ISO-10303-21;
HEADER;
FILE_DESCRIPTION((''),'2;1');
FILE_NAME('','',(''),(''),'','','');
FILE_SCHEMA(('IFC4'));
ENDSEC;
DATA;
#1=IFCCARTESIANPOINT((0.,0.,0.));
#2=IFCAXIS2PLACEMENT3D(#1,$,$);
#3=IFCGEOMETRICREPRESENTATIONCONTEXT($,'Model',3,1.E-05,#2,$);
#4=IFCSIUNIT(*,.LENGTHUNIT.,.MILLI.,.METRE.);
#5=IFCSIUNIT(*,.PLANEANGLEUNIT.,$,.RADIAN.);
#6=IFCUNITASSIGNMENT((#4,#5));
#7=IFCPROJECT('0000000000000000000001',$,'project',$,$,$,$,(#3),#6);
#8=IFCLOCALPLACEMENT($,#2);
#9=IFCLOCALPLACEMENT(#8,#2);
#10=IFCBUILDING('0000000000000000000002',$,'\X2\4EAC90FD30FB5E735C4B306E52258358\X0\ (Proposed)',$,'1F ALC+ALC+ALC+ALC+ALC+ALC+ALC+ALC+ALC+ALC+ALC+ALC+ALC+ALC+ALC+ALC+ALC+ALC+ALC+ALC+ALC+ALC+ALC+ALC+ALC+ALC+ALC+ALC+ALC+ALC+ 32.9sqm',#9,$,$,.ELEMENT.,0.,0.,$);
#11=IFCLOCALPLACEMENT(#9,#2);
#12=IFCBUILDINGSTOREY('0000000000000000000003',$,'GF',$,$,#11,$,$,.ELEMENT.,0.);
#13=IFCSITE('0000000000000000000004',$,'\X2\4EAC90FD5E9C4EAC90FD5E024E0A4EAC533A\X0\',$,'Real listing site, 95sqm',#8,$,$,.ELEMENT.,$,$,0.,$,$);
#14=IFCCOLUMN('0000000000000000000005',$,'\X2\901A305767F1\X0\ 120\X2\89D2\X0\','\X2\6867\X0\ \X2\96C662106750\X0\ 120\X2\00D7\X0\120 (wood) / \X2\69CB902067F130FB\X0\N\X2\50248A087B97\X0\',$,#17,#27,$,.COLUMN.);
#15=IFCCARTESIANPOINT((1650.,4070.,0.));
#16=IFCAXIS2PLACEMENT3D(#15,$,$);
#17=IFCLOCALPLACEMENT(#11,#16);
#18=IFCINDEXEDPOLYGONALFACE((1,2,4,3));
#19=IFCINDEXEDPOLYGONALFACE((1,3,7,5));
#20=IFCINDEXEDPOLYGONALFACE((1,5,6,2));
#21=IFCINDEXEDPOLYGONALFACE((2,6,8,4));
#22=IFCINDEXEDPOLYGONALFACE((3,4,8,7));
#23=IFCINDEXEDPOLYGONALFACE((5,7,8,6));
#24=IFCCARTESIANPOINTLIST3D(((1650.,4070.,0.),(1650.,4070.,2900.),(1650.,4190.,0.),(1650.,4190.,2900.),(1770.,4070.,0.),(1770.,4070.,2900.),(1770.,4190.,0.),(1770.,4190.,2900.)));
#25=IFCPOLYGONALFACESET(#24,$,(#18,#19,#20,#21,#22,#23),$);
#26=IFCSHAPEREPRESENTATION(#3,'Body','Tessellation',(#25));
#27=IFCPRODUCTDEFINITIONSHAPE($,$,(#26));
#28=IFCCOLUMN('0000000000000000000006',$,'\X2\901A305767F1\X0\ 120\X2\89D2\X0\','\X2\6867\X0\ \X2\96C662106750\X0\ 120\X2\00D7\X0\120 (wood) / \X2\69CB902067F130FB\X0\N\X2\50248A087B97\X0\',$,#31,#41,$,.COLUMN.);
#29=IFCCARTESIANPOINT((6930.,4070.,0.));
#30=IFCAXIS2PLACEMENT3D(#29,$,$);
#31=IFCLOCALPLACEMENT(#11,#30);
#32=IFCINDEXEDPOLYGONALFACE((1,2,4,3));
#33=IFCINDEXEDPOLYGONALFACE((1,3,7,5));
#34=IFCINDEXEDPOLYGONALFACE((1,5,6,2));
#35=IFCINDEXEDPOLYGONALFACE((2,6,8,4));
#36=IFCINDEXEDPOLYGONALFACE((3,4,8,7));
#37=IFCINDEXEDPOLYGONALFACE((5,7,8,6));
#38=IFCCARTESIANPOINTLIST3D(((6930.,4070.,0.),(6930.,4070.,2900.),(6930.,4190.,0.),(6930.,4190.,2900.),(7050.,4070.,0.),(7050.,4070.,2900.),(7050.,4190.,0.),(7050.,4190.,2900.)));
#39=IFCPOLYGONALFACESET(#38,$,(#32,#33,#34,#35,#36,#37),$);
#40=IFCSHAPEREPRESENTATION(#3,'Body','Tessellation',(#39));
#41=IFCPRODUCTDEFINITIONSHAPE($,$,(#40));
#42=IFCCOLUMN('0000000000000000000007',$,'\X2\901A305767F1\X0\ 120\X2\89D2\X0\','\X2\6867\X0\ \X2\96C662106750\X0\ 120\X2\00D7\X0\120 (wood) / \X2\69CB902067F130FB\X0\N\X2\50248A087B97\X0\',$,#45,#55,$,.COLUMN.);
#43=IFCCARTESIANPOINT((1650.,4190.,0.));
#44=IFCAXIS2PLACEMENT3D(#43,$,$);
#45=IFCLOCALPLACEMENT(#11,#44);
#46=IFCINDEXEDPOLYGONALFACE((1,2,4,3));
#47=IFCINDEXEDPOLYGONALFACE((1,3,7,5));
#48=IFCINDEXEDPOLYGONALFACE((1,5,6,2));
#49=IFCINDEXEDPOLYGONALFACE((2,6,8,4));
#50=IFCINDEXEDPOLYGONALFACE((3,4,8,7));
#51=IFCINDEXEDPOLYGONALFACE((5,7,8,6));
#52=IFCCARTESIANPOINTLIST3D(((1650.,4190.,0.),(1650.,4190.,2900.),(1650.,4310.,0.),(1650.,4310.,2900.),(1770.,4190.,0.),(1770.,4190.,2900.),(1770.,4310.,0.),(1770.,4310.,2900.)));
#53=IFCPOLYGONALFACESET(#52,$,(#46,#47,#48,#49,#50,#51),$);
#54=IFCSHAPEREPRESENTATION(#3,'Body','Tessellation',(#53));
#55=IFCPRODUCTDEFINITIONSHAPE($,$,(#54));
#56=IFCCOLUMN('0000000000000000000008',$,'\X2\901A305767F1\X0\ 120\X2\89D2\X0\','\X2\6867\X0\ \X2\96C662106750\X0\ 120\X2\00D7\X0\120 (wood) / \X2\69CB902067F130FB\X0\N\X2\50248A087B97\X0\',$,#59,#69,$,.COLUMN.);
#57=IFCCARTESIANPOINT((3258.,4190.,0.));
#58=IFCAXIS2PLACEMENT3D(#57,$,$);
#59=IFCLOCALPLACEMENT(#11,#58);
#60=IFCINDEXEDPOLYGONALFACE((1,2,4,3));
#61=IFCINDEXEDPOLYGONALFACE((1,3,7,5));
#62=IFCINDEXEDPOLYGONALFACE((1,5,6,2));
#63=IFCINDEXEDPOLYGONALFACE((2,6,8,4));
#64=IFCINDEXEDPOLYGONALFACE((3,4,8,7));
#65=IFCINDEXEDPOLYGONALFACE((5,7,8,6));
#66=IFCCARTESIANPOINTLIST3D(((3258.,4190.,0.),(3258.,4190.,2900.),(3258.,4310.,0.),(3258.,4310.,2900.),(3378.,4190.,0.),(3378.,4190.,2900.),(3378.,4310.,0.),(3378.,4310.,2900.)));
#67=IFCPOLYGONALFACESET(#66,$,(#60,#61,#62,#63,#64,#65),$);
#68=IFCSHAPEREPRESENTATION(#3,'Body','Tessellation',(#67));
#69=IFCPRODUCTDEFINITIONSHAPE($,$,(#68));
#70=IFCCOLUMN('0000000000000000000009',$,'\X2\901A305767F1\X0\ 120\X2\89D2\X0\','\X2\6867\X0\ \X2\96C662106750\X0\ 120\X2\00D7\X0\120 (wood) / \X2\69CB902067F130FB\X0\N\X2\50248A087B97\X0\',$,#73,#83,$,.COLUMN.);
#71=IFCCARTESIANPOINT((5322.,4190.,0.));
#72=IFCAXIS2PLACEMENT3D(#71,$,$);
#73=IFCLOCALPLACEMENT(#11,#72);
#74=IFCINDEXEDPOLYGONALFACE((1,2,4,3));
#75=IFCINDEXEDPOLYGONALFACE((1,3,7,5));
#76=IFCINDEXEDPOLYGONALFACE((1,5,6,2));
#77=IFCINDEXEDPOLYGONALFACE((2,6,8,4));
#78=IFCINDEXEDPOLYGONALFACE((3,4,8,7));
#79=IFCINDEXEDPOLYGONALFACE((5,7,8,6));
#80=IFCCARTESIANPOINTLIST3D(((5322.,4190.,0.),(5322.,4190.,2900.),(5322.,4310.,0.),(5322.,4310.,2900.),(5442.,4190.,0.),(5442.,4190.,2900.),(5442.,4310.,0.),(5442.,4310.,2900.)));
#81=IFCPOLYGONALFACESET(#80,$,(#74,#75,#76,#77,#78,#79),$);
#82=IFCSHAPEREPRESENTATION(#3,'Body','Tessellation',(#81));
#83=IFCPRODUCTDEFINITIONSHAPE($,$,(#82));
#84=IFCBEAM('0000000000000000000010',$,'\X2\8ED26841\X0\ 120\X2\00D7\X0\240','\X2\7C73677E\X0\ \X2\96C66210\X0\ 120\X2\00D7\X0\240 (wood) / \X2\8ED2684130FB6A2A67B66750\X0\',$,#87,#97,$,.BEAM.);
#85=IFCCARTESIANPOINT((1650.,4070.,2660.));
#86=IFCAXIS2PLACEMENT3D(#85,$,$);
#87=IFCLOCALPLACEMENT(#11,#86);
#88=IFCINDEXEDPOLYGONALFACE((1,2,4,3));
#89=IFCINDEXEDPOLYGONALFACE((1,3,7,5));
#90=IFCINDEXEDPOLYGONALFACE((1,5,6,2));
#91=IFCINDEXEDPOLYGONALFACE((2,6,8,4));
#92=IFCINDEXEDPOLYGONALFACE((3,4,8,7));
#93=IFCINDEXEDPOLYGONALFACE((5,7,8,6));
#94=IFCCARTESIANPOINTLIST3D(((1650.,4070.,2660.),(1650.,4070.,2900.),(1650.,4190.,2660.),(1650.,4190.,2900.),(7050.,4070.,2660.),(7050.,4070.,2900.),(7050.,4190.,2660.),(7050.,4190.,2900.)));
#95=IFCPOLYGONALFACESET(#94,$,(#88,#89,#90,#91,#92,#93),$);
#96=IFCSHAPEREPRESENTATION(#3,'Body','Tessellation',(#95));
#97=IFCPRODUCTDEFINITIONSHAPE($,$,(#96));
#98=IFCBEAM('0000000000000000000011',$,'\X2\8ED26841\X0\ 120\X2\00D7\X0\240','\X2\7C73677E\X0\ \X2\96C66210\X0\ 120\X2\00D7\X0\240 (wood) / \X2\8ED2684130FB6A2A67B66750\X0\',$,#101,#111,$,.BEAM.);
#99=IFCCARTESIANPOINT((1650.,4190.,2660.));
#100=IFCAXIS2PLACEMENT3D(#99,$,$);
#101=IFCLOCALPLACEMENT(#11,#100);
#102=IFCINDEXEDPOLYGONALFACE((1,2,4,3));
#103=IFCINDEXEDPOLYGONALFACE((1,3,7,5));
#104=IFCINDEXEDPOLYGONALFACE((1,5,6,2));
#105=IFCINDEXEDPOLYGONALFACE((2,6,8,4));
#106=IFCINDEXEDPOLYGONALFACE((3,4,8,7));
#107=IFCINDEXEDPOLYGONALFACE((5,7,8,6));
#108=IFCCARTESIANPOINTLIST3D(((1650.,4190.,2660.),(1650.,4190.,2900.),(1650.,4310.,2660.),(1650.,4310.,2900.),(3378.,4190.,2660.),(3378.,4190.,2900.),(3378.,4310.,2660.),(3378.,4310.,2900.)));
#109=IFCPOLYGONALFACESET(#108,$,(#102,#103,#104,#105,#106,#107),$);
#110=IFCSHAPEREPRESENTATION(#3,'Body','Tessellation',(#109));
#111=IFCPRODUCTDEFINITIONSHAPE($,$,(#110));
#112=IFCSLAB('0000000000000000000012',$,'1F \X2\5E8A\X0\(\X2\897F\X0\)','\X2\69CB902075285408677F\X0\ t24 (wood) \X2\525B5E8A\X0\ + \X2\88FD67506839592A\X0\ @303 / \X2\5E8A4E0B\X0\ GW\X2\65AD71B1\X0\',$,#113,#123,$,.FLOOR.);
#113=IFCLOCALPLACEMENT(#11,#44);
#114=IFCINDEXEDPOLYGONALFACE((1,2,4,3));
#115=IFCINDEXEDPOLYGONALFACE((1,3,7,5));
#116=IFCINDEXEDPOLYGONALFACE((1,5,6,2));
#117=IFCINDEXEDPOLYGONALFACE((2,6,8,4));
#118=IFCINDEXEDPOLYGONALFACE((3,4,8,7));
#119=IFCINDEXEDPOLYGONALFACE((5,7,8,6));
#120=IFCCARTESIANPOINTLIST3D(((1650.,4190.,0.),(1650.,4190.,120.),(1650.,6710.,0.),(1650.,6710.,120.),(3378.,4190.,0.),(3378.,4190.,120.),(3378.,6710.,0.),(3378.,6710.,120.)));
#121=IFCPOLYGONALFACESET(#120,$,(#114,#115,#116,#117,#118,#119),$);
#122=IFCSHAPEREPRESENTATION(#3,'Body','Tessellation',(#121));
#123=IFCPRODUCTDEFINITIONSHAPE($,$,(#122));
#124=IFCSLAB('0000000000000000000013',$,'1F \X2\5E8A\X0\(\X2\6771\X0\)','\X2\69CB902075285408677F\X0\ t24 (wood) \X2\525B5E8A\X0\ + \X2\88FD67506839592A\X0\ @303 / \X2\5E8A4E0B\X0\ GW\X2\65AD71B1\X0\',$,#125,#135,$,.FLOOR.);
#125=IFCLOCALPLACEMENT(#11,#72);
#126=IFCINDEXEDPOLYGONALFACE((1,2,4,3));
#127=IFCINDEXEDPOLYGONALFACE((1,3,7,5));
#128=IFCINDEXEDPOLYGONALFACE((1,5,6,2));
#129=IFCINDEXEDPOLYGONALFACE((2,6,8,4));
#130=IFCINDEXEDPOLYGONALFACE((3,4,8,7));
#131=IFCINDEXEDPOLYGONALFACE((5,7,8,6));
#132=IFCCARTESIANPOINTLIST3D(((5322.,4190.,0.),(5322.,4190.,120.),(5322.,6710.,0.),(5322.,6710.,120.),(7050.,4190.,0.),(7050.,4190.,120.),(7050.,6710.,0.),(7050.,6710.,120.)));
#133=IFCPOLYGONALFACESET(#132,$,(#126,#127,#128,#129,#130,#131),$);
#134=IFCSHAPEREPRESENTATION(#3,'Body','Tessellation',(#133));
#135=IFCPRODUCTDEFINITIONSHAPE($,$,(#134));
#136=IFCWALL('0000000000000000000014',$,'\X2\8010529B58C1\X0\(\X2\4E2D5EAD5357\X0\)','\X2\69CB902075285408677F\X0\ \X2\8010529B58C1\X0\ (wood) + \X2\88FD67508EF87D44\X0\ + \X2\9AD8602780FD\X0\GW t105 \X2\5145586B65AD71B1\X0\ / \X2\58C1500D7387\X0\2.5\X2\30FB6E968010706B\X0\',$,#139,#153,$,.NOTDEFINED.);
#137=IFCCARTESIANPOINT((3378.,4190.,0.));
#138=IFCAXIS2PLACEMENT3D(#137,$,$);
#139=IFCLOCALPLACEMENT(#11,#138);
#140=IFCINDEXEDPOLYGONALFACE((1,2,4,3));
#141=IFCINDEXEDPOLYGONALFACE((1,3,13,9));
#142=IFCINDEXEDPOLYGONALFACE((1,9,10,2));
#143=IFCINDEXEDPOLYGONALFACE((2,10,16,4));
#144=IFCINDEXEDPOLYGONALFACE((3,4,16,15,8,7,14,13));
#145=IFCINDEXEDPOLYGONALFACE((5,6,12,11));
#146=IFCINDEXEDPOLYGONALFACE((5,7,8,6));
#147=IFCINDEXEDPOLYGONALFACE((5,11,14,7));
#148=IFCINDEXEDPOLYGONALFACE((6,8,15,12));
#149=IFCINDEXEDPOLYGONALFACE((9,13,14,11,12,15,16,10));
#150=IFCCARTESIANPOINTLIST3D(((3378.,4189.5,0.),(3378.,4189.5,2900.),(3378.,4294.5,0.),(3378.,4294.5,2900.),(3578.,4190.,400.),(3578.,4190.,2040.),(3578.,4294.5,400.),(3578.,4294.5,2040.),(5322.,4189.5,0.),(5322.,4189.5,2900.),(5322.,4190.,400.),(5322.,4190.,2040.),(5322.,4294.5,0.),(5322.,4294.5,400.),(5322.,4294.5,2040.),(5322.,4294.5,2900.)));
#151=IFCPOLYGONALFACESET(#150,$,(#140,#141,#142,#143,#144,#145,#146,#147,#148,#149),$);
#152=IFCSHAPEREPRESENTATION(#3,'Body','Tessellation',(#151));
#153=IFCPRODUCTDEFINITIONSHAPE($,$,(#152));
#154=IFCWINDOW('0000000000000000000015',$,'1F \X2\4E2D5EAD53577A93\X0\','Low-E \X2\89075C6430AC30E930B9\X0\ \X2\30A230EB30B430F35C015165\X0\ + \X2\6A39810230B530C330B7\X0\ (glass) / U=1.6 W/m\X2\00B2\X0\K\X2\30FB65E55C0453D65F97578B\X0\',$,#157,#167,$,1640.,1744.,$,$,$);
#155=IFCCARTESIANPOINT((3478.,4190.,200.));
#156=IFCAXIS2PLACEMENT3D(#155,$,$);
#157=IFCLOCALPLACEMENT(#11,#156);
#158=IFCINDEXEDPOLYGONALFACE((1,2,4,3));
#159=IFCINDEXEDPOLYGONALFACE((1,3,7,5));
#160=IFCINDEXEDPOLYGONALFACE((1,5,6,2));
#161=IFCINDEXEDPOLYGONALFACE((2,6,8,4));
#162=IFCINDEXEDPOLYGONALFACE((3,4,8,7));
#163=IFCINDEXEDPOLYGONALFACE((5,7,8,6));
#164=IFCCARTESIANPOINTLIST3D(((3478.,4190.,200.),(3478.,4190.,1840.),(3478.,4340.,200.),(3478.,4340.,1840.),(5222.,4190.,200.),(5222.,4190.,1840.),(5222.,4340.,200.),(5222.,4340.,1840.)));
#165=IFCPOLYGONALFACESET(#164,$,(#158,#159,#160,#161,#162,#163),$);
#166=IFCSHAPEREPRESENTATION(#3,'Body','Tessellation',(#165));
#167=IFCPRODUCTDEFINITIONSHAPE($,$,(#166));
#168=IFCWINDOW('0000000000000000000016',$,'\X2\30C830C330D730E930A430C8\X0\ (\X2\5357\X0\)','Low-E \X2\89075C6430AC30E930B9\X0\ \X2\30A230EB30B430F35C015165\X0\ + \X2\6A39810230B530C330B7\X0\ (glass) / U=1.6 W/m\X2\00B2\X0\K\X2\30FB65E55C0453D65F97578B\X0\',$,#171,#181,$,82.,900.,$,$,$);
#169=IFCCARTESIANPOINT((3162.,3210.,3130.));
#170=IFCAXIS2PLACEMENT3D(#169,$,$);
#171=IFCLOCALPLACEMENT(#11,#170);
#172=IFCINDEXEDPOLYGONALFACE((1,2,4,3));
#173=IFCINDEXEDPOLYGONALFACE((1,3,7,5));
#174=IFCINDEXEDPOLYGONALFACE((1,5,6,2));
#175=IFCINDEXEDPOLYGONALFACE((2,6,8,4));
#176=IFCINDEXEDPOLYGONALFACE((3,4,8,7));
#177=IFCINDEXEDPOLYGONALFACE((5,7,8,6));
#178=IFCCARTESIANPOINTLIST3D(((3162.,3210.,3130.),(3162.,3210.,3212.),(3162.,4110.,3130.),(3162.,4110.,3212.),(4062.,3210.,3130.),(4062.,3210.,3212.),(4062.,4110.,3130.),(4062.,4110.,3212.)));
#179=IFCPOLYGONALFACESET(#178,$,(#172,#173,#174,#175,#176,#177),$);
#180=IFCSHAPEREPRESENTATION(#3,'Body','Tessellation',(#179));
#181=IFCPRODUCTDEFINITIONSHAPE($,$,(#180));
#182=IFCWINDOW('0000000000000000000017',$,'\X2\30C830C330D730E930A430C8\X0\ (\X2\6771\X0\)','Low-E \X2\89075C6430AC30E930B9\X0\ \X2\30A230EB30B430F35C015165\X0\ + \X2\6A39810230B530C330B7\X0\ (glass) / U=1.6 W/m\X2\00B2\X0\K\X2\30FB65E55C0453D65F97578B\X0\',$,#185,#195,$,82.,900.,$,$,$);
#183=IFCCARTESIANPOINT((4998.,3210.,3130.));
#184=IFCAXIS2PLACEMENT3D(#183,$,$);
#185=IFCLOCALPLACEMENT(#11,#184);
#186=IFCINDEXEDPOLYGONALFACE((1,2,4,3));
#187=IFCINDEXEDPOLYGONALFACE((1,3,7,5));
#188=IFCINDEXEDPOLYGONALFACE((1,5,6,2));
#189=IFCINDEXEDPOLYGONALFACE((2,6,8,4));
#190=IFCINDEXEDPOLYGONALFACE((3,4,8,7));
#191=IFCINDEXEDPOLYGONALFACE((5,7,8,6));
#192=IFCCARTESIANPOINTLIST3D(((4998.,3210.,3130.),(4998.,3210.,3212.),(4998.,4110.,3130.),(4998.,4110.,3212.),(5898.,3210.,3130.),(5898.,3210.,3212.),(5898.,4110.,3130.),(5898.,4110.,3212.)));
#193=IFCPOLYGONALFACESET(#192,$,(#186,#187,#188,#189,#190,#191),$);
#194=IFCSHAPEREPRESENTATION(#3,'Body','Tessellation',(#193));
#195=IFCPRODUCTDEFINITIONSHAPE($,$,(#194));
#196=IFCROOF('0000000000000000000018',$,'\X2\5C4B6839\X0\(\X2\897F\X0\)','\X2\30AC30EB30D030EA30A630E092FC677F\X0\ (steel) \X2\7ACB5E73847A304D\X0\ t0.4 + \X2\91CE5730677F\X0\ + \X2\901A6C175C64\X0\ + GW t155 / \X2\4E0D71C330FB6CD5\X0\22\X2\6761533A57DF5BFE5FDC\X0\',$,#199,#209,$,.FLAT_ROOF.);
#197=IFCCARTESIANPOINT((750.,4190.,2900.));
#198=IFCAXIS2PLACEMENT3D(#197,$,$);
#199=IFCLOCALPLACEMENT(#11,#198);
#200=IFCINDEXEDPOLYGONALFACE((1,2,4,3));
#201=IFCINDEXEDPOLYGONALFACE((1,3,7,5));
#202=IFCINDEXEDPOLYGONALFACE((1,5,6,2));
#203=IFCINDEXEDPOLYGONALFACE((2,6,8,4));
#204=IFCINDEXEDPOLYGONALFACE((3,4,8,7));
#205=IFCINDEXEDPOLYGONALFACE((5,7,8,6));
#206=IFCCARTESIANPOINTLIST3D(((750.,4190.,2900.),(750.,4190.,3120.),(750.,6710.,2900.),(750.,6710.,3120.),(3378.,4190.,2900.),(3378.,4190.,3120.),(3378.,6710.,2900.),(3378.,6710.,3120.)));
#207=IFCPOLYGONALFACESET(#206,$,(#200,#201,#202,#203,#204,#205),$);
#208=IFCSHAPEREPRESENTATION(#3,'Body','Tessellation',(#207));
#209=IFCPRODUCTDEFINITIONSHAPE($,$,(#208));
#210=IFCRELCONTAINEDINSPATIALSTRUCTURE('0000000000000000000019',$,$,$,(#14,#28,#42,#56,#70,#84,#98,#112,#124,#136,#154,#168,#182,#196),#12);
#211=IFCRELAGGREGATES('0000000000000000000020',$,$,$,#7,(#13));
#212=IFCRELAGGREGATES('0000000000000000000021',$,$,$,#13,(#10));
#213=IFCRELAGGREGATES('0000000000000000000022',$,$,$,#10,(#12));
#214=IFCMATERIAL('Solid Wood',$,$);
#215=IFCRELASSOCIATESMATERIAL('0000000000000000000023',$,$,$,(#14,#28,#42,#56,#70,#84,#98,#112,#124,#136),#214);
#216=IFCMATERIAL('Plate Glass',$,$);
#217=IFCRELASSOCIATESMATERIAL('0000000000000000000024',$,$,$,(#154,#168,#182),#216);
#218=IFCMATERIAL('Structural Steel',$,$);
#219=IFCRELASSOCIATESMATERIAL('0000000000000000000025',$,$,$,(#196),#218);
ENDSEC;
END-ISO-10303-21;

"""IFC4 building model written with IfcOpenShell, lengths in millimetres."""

from ifc_helpers import new_model, si_unit, frame, frame_2d, origin, place, context, project, spatial, rectangle, extrude, material, element, fill, save


model = new_model("IFC4")

# Units and contexts
model_context = context("Model", 3, precision=1e-05, world=origin())
ifc_project = project(units=[si_unit("LENGTHUNIT", "METRE", prefix="MILLI"), si_unit("PLANEANGLEUNIT", "RADIAN")], contexts=[model_context])

# Site, building, storey
site_placement = place(None, origin())
site = spatial("IfcSite", under=ifc_project, at=site_placement, Name="京都府京都市上京区", ObjectType="Real listing site, 95sqm", CompositionType="ELEMENT", RefElevation=0.0)
building_placement = place(site_placement, origin())
building = spatial("IfcBuilding", under=site, at=building_placement, Name="京都・平屋の別荘 (Proposed)", ObjectType="1F ALC+ALC+ALC+ALC+ALC+ALC+ALC+ALC+ALC+ALC+ALC+ALC+ALC+ALC+ALC+ALC+ALC+ALC+ALC+ALC+ALC+ALC+ALC+ALC+ALC+ALC+ALC+ALC+ALC+ALC+ 32.9sqm", CompositionType="ELEMENT", ElevationOfRefHeight=0.0, ElevationOfTerrain=0.0)
storey_placement = place(building_placement, origin())
storey = spatial("IfcBuildingStorey", under=building, at=storey_placement, Name="GF", CompositionType="ELEMENT", Elevation=0.0)

# Columns
ifc_material_1 = material(Name="Solid Wood")
column_1_placement = place(storey_placement, frame((1650.0, 4070.0, 0.0)))
element("IfcColumn", 1, at=column_1_placement, inside=storey, material=ifc_material_1, Name="通し柱 120角", Description="桧 集成材 120×120 (wood) / 構造柱・N値計算", PredefinedType="COLUMN", context=model_context, shape_type="SweptSolid", body=[
    extrude(rectangle(XDim=120.0, YDim=120.0, at=frame_2d((60.0, 60.0))), frame((1650.0, 4070.0, 0.0)), (0.0, 0.0, 1.0), 2900.0),
])
column_2_placement = place(storey_placement, frame((6930.0, 4070.0, 0.0)))
element("IfcColumn", 2, at=column_2_placement, inside=storey, material=ifc_material_1, Name="通し柱 120角", Description="桧 集成材 120×120 (wood) / 構造柱・N値計算", PredefinedType="COLUMN", context=model_context, shape_type="SweptSolid", body=[
    extrude(rectangle(XDim=120.0, YDim=120.0, at=frame_2d((60.0, 60.0))), frame((6930.0, 4070.0, 0.0)), (0.0, 0.0, 1.0), 2900.0),
])
column_3_placement = place(storey_placement, frame((1650.0, 4190.0, 0.0)))
element("IfcColumn", 3, at=column_3_placement, inside=storey, material=ifc_material_1, Name="通し柱 120角", Description="桧 集成材 120×120 (wood) / 構造柱・N値計算", PredefinedType="COLUMN", context=model_context, shape_type="SweptSolid", body=[
    extrude(rectangle(XDim=120.0, YDim=120.0, at=frame_2d((60.0, 60.0))), frame((1650.0, 4190.0, 0.0)), (0.0, 0.0, 1.0), 2900.0),
])
column_4_placement = place(storey_placement, frame((3258.0, 4190.0, 0.0)))
element("IfcColumn", 4, at=column_4_placement, inside=storey, material=ifc_material_1, Name="通し柱 120角", Description="桧 集成材 120×120 (wood) / 構造柱・N値計算", PredefinedType="COLUMN", context=model_context, shape_type="SweptSolid", body=[
    extrude(rectangle(XDim=120.0, YDim=120.0, at=frame_2d((60.0, 60.0))), frame((3258.0, 4190.0, 0.0)), (0.0, 0.0, 1.0), 2900.0),
])
column_5_placement = place(storey_placement, frame((5322.0, 4190.0, 0.0)))
element("IfcColumn", 5, at=column_5_placement, inside=storey, material=ifc_material_1, Name="通し柱 120角", Description="桧 集成材 120×120 (wood) / 構造柱・N値計算", PredefinedType="COLUMN", context=model_context, shape_type="SweptSolid", body=[
    extrude(rectangle(XDim=120.0, YDim=120.0, at=frame_2d((60.0, 60.0))), frame((5322.0, 4190.0, 0.0)), (0.0, 0.0, 1.0), 2900.0),
])

# Beams
beam_1_placement = place(storey_placement, frame((1650.0, 4070.0, 2660.0)))
element("IfcBeam", 6, at=beam_1_placement, inside=storey, material=ifc_material_1, Name="軒桁 120×240", Description="米松 集成 120×240 (wood) / 軒桁・横架材", PredefinedType="BEAM", context=model_context, shape_type="SweptSolid", body=[
    extrude(rectangle(XDim=5400.0, YDim=120.0, at=frame_2d((2700.0, 60.0))), frame((1650.0, 4070.0, 2660.0)), (0.0, 0.0, 1.0), 240.0),
])
beam_2_placement = place(storey_placement, frame((1650.0, 4190.0, 2660.0)))
element("IfcBeam", 7, at=beam_2_placement, inside=storey, material=ifc_material_1, Name="軒桁 120×240", Description="米松 集成 120×240 (wood) / 軒桁・横架材", PredefinedType="BEAM", context=model_context, shape_type="SweptSolid", body=[
    extrude(rectangle(XDim=1728.0, YDim=120.0, at=frame_2d((864.0, 60.0))), frame((1650.0, 4190.0, 2660.0)), (0.0, 0.0, 1.0), 240.0),
])

# Slabs
slab_1_placement = place(storey_placement, frame((1650.0, 4190.0, 0.0)))
element("IfcSlab", 8, at=slab_1_placement, inside=storey, material=ifc_material_1, Name="1F 床(西)", Description="構造用合板 t24 (wood) 剛床 + 製材根太 @303 / 床下 GW断熱", PredefinedType="FLOOR", context=model_context, shape_type="SweptSolid", body=[
    extrude(rectangle(XDim=1728.0, YDim=2520.0, at=frame_2d((864.0, 1260.0))), frame((1650.0, 4190.0, 0.0)), (0.0, 0.0, 1.0), 120.0),
])
slab_2_placement = place(storey_placement, frame((5322.0, 4190.0, 0.0)))
element("IfcSlab", 9, at=slab_2_placement, inside=storey, material=ifc_material_1, Name="1F 床(東)", Description="構造用合板 t24 (wood) 剛床 + 製材根太 @303 / 床下 GW断熱", PredefinedType="FLOOR", context=model_context, shape_type="SweptSolid", body=[
    extrude(rectangle(XDim=1728.0, YDim=2520.0, at=frame_2d((864.0, 1260.0))), frame((5322.0, 4190.0, 0.0)), (0.0, 0.0, 1.0), 120.0),
])

# Wall, opening, window
wall_1_placement = place(storey_placement, frame((3378.0, 4190.0, 0.0)))
wall_1 = element("IfcWall", 10, at=wall_1_placement, inside=storey, material=ifc_material_1, Name="耐力壁(中庭南)", Description="構造用合板 耐力壁 (wood) + 製材軸組 + 高性能GW t105 充填断熱 / 壁倍率2.5・準耐火", PredefinedType="NOTDEFINED", context=model_context, shape_type="SweptSolid", body=[
    extrude(rectangle(XDim=1944.0, YDim=105.0, at=frame_2d((972.0, 52.0))), frame((3378.0, 4190.0, 0.0)), (0.0, 0.0, 1.0), 2900.0),
])
opening_placement = place(storey_placement, frame((3478.0, 4190.0, 200.0)))
opening = element("IfcOpeningElement", 11, at=opening_placement, cuts=wall_1, PredefinedType="NOTDEFINED", context=model_context, shape_type="SweptSolid", body=[
    extrude(rectangle(XDim=1744.0, YDim=150.0, at=frame_2d((872.0, 75.0))), frame((3478.0, 4190.0, 200.0)), (0.0, 0.0, 1.0), 1640.0),
])
ifc_material_2 = material(Name="Plate Glass")
window_1_placement = place(storey_placement, frame((3478.0, 4190.0, 200.0)))
window_1 = element("IfcWindow", 12, at=window_1_placement, inside=storey, material=ifc_material_2, Name="1F 中庭南窓", Description="Low-E 複層ガラス アルゴン封入 + 樹脂サッシ (glass) / U=1.6 W/m²K・日射取得型", OverallHeight=1640.0, OverallWidth=1744.0, context=model_context, shape_type="SweptSolid", body=[
    extrude(rectangle(XDim=1744.0, YDim=150.0, at=frame_2d((872.0, 75.0))), frame((3478.0, 4190.0, 200.0)), (0.0, 0.0, 1.0), 1640.0),
])
fill(opening, window_1)

# Windows
window_2_placement = place(storey_placement, frame((3162.0, 3210.0, 3130.0)))
element("IfcWindow", 13, at=window_2_placement, inside=storey, material=ifc_material_2, Name="トップライト (南)", Description="Low-E 複層ガラス アルゴン封入 + 樹脂サッシ (glass) / U=1.6 W/m²K・日射取得型", OverallHeight=82.0, OverallWidth=900.0, context=model_context, shape_type="SweptSolid", body=[
    extrude(rectangle(XDim=900.0, YDim=900.0, at=frame_2d((450.0, 450.0))), frame((3162.0, 3210.0, 3130.0)), (0.0, 0.0, 1.0), 82.0),
])
window_3_placement = place(storey_placement, frame((4998.0, 3210.0, 3130.0)))
element("IfcWindow", 14, at=window_3_placement, inside=storey, material=ifc_material_2, Name="トップライト (東)", Description="Low-E 複層ガラス アルゴン封入 + 樹脂サッシ (glass) / U=1.6 W/m²K・日射取得型", OverallHeight=82.0, OverallWidth=900.0, context=model_context, shape_type="SweptSolid", body=[
    extrude(rectangle(XDim=900.0, YDim=900.0, at=frame_2d((450.0, 450.0))), frame((4998.0, 3210.0, 3130.0)), (0.0, 0.0, 1.0), 82.0),
])

# Roof
ifc_material_3 = material(Name="Structural Steel")
roof_1_placement = place(storey_placement, frame((750.0, 4190.0, 2900.0)))
element("IfcRoof", 15, at=roof_1_placement, inside=storey, material=ifc_material_3, Name="屋根(西)", Description="ガルバリウム鋼板 (steel) 立平葺き t0.4 + 野地板 + 通気層 + GW t155 / 不燃・法22条区域対応", PredefinedType="FLAT_ROOF", context=model_context, shape_type="SweptSolid", body=[
    extrude(rectangle(XDim=2628.0, YDim=2520.0, at=frame_2d((1314.0, 1260.0))), frame((750.0, 4190.0, 2900.0)), (0.0, 0.0, 1.0), 220.0),
])

save(model, "model.ifc")
